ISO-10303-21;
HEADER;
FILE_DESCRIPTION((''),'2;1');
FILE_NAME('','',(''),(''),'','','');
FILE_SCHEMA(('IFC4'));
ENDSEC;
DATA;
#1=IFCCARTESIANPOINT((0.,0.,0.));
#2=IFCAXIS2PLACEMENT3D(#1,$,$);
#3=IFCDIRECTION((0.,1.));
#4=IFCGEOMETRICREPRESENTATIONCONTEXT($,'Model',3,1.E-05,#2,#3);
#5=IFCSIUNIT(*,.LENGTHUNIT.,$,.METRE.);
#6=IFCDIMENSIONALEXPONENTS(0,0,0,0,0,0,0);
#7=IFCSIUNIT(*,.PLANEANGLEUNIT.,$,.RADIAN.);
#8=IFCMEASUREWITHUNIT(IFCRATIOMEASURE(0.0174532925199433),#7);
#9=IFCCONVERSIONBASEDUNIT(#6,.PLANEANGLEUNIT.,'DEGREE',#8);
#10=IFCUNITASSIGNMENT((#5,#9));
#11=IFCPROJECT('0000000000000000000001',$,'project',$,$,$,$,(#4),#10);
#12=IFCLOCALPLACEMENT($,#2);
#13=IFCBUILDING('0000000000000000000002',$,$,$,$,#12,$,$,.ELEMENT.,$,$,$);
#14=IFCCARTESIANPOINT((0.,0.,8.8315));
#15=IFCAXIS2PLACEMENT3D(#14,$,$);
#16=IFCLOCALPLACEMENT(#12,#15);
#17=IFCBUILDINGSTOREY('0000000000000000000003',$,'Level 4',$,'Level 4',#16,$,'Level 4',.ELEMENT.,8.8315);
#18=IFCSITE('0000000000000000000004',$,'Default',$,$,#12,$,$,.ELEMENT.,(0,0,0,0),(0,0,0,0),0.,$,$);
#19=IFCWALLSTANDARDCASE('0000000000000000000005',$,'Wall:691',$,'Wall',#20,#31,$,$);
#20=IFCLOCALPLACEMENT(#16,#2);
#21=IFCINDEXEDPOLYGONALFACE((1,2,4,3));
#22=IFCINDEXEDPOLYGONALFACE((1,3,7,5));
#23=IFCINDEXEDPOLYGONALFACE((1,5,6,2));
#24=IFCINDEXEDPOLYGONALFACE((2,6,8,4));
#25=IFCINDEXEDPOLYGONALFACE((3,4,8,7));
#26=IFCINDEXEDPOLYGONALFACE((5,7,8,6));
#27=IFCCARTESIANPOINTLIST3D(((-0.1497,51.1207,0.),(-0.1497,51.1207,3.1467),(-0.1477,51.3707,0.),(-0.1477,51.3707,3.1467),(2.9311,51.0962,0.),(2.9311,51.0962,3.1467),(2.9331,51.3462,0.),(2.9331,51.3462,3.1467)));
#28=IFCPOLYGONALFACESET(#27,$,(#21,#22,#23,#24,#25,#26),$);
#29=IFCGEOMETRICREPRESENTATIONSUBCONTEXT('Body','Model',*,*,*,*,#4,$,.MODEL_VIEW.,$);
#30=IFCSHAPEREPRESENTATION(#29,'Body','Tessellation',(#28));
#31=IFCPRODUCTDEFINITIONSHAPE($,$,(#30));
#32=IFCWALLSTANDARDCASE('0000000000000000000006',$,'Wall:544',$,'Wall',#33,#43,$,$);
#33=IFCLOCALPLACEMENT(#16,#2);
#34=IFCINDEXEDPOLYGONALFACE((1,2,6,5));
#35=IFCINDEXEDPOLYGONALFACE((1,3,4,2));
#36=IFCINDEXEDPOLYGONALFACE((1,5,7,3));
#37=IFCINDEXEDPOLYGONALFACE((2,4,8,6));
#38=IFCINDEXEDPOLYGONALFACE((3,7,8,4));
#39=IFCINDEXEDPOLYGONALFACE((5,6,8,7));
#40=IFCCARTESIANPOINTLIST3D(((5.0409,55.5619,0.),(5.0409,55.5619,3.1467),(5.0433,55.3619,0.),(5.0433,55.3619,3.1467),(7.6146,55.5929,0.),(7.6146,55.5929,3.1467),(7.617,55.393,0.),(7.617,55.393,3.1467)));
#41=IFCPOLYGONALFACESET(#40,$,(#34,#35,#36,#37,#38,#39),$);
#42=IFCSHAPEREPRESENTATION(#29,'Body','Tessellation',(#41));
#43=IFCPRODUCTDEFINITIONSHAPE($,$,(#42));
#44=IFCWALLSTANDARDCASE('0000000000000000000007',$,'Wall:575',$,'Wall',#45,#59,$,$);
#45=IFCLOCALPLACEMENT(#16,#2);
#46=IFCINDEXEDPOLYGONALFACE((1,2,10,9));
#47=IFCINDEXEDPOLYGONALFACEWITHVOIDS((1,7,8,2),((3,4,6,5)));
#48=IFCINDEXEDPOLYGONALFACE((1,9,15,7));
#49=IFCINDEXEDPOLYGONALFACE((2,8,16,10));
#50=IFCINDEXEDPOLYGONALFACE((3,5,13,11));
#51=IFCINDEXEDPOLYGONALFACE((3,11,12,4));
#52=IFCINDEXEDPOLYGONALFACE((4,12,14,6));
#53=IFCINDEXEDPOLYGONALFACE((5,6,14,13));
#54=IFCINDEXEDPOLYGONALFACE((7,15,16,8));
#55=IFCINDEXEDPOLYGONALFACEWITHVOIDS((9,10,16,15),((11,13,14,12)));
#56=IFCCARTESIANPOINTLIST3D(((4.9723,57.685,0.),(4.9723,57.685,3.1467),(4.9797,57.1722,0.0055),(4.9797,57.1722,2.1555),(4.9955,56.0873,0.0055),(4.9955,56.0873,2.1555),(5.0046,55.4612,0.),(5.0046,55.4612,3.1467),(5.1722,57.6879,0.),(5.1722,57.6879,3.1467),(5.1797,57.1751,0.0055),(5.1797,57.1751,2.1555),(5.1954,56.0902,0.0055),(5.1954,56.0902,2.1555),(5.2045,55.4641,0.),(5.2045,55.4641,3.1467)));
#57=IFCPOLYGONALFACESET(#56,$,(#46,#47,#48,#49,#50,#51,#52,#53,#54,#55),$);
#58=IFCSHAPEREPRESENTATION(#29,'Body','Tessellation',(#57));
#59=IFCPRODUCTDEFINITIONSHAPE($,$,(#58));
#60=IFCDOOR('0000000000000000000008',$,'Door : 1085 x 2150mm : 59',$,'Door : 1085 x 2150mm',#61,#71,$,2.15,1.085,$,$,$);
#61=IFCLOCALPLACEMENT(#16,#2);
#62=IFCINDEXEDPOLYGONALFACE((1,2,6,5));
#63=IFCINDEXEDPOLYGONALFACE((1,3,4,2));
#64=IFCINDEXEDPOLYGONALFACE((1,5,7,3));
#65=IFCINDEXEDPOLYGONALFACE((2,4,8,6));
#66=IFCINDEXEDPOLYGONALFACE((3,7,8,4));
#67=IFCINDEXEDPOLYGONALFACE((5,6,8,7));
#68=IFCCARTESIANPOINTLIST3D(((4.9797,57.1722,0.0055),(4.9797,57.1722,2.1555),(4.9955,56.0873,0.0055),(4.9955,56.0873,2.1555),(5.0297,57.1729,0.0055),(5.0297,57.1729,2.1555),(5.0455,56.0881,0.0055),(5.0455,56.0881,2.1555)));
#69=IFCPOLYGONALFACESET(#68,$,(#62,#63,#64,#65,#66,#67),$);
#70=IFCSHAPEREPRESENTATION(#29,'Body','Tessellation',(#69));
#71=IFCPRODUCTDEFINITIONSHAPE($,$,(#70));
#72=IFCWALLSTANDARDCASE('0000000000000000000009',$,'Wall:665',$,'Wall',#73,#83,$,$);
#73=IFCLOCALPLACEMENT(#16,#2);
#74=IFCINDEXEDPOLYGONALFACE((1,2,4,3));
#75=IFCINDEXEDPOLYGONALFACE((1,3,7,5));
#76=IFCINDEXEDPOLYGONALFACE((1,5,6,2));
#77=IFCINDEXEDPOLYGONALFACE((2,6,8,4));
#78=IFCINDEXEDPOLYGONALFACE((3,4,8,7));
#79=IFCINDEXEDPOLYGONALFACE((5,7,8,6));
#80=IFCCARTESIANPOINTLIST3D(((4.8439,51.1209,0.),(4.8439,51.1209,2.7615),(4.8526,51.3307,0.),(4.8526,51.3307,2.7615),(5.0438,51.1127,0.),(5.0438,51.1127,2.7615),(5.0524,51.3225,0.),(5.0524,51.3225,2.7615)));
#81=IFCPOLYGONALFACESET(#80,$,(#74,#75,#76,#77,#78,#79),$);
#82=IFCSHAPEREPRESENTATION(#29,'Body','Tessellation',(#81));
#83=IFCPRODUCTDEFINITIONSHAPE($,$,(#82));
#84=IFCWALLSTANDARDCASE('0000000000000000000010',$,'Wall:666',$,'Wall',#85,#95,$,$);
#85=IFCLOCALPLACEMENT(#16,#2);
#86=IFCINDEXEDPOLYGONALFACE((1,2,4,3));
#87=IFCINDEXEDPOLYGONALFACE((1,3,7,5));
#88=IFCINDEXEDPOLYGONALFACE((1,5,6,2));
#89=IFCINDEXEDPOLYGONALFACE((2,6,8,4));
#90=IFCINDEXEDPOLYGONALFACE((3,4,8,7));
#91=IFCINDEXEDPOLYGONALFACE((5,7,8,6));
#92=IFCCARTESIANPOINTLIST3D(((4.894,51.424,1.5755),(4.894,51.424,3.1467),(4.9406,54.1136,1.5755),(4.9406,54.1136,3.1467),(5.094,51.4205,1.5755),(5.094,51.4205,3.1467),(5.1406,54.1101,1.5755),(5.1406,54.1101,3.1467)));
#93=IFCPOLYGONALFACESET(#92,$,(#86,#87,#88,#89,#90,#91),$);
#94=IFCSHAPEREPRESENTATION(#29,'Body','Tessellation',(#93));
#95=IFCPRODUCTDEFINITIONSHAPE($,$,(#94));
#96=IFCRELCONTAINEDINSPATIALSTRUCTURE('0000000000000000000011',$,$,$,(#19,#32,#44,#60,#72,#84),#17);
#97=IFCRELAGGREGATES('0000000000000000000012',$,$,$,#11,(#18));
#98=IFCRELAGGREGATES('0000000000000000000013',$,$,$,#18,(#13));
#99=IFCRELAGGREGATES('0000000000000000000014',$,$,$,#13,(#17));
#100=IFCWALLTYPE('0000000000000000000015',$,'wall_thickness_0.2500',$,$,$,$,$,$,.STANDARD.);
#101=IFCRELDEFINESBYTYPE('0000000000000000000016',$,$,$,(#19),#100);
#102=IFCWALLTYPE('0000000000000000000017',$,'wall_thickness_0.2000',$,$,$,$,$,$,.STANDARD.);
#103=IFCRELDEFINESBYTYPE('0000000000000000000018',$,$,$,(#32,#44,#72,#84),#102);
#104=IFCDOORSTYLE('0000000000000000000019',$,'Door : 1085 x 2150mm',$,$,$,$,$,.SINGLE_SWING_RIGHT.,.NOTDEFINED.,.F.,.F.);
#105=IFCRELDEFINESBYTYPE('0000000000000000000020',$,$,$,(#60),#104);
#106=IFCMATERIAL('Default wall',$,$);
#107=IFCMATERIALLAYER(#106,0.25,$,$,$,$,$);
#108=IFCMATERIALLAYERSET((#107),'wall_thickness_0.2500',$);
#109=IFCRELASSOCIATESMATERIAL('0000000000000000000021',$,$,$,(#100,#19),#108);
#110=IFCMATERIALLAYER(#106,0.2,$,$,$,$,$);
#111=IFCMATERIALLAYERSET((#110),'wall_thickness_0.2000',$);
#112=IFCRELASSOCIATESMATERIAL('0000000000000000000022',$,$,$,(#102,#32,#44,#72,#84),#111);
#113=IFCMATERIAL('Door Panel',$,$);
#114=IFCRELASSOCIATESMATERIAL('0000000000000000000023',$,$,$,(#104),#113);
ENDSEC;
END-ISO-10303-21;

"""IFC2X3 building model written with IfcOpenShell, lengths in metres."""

from ifc_helpers import new_model, entity, si_unit, converted_unit, direction, frame, frame_2d, origin, origin_2d_with_axis, place, context, subcontext, project, spatial, polyline, rectangle, outline, extrude, source, transform, mapped, material, layer, layer_set, layer_usage, type_object, type_shapes, element, fill, save


model = new_model("IFC2X3")

# Units and contexts
model_context = context("Model", 3, precision=1e-05, world=origin(), true_north=direction((0.0, 1.0)))
body_context = subcontext(model_context, "Body", "Model", "MODEL_VIEW")
ifc_project = project(units=[si_unit("LENGTHUNIT", "METRE"), converted_unit("PLANEANGLEUNIT", "DEGREE", entity("IfcRatioMeasure", 0.0174532925199433), si_unit("PLANEANGLEUNIT", "RADIAN"), dimensions=[0, 0, 0, 0, 0, 0, 0])], contexts=[model_context])

# Site, building, storey
placement_1 = place(None, origin())
site = spatial("IfcSite", under=ifc_project, at=placement_1, Name="Default", CompositionType="ELEMENT", RefLatitude=(0, 0, 0, 0), RefLongitude=(0, 0, 0, 0), RefElevation=0.0)
building = spatial("IfcBuilding", under=site, at=placement_1, CompositionType="ELEMENT")
storey_placement = place(placement_1, frame((0.0, 0.0, 8.8315)))
storey = spatial("IfcBuildingStorey", under=building, at=storey_placement, Name="Level 4", ObjectType="Level 4", LongName="Level 4", CompositionType="ELEMENT", Elevation=8.8315)

# Walls
ifc_material_1 = material(Name="Default wall")
ifc_layer_1 = layer(ifc_material_1, 0.25)
ifc_layer_set_1 = layer_set([ifc_layer_1], Name="wall_thickness_0.2500")
ifc_layer_usage_1 = layer_usage(ifc_layer_set_1, "AXIS2", "POSITIVE", -0.125)
wall_type_1 = type_object("IfcWallType", Name="wall_thickness_0.2500", PredefinedType="STANDARD", material=ifc_layer_set_1)
wall_1_placement = place(storey_placement, frame((-0.1487, 51.2457, 0.0), z_axis=(0.0, 0.0, 1.0), x_axis=(0.999968, -0.007944, 0.0)))
element("IfcWallStandardCase", 1, at=wall_1_placement, inside=storey, type_object=wall_type_1, material=ifc_layer_usage_1, Name="Wall:691", ObjectType="Wall", context=body_context, shape_type="SweptSolid", body=[
    extrude(outline(polyline([(3.0809, -0.125), (3.0809, 0.125), (0.0, 0.125), (0.0, -0.125), (3.0809, -0.125)])), origin(), (0.0, 0.0, 1.0), 3.1467),
])
ifc_layer_2 = layer(ifc_material_1, 0.2)
ifc_layer_set_2 = layer_set([ifc_layer_2], Name="wall_thickness_0.2000")
ifc_layer_usage_2 = layer_usage(ifc_layer_set_2, "AXIS2", "POSITIVE", -0.1)
wall_type_2 = type_object("IfcWallType", Name="wall_thickness_0.2000", PredefinedType="STANDARD", material=ifc_layer_set_2)
wall_2_placement = place(storey_placement, frame((5.0421, 55.4619, 0.0), z_axis=(0.0, 0.0, 1.0), x_axis=(0.999927, 0.012055, 0.0)))
element("IfcWallStandardCase", 2, at=wall_2_placement, inside=storey, type_object=wall_type_2, material=ifc_layer_usage_2, Name="Wall:544", ObjectType="Wall", context=body_context, shape_type="SweptSolid", body=[
    extrude(outline(polyline([(2.5739, -0.1), (2.5739, 0.1), (0.0, 0.1), (0.0, -0.1), (2.5739, -0.1)])), origin(), (0.0, 0.0, 1.0), 3.1467),
])

# Wall, opening, door
wall_3_placement = place(storey_placement, frame((5.1046, 55.4627, 0.0), z_axis=(0.0, 0.0, 1.0), x_axis=(-0.014522, 0.999895, 0.0)))
wall_3 = element("IfcWallStandardCase", 3, at=wall_3_placement, inside=storey, type_object=wall_type_2, material=ifc_layer_usage_2, Name="Wall:575", ObjectType="Wall", context=body_context, shape_type="SweptSolid", body=[
    extrude(outline(polyline([(2.224, -0.1), (2.224, 0.1), (0.0, 0.1), (0.0, -0.1), (2.224, -0.1)])), origin(), (0.0, 0.0, 1.0), 3.1467),
])
opening_1_placement = place(wall_3_placement, frame((0.6262, -0.1, 0.0055)))
opening_1 = element("IfcOpeningElement", 4, at=opening_1_placement, cuts=wall_3, ObjectType="Opening", context=body_context, shape_type="SweptSolid", body=[
    extrude(rectangle(XDim=1.085, YDim=2.15, at=frame_2d((1.075, 0.5425), x_axis=(0.0, 1.0))), frame((0.0, 0.0, 0.0), z_axis=(0.0, 1.0, 0.0), x_axis=(0.0, 0.0, 1.0)), (0.0, 0.0, 1.0), 0.2),
])
ifc_material_2 = material(Name="Door Panel")
door_style = type_object("IfcDoorStyle", Name="Door : 1085 x 2150mm", ConstructionType="NOTDEFINED", OperationType="SINGLE_SWING_RIGHT", ParameterTakesPrecedence=False, Sizeable=False, material=ifc_material_2)
shared_shape_1 = source(origin(), body_context, "Body", "SweptSolid", [
    extrude(rectangle(XDim=0.05, YDim=1.085, at=origin_2d_with_axis()), frame((0.5425, 0.175, 0.0), z_axis=(0.0, 0.0, 1.0), x_axis=(0.0, 1.0, 0.0)), (0.0, 0.0, 1.0), 2.15),
])
type_shapes(door_style, [shared_shape_1])
door_placement = place(opening_1_placement, origin())
door = element("IfcDoor", 5, at=door_placement, inside=storey, type_object=door_style, Name="Door : 1085 x 2150mm : 59", ObjectType="Door : 1085 x 2150mm", OverallHeight=2.15, OverallWidth=1.085, context=body_context, shape_type="MappedRepresentation", body=[
    mapped(shared_shape_1, transform((0.0, 0.0, 0.0), scale=1.0)),
])
fill(opening_1, door)

# Walls
wall_4_placement = place(storey_placement, frame((4.9525, 51.3266, 0.0), z_axis=(0.0, 0.0, 1.0), x_axis=(-0.041288, -0.999147, 0.0)))
element("IfcWallStandardCase", 6, at=wall_4_placement, inside=storey, type_object=wall_type_2, material=ifc_layer_usage_2, Name="Wall:665", ObjectType="Wall", context=body_context, shape_type="SweptSolid", body=[
    extrude(outline(polyline([(0.21, -0.1), (0.21, 0.1), (0.0, 0.1), (0.0, -0.1), (0.21, -0.1)])), origin(), (0.0, 0.0, 1.0), 2.7615),
])
placement_2 = place(placement_1, frame((0.0, 0.0, 10.407)))
wall_5_placement = place(placement_2, frame((4.994, 51.4223, 0.0), z_axis=(0.0, 0.0, 1.0), x_axis=(0.017332, 0.99985, 0.0)))
element("IfcWallStandardCase", 7, at=wall_5_placement, inside=storey, type_object=wall_type_2, material=ifc_layer_usage_2, Name="Wall:666", ObjectType="Wall", context=body_context, shape_type="SweptSolid", body=[
    extrude(outline(polyline([(2.69, -0.1), (2.69, 0.1), (0.0, 0.1), (0.0, -0.1), (2.69, -0.1)])), origin(), (0.0, 0.0, 1.0), 1.5712),
])

save(model, "model.ifc")
